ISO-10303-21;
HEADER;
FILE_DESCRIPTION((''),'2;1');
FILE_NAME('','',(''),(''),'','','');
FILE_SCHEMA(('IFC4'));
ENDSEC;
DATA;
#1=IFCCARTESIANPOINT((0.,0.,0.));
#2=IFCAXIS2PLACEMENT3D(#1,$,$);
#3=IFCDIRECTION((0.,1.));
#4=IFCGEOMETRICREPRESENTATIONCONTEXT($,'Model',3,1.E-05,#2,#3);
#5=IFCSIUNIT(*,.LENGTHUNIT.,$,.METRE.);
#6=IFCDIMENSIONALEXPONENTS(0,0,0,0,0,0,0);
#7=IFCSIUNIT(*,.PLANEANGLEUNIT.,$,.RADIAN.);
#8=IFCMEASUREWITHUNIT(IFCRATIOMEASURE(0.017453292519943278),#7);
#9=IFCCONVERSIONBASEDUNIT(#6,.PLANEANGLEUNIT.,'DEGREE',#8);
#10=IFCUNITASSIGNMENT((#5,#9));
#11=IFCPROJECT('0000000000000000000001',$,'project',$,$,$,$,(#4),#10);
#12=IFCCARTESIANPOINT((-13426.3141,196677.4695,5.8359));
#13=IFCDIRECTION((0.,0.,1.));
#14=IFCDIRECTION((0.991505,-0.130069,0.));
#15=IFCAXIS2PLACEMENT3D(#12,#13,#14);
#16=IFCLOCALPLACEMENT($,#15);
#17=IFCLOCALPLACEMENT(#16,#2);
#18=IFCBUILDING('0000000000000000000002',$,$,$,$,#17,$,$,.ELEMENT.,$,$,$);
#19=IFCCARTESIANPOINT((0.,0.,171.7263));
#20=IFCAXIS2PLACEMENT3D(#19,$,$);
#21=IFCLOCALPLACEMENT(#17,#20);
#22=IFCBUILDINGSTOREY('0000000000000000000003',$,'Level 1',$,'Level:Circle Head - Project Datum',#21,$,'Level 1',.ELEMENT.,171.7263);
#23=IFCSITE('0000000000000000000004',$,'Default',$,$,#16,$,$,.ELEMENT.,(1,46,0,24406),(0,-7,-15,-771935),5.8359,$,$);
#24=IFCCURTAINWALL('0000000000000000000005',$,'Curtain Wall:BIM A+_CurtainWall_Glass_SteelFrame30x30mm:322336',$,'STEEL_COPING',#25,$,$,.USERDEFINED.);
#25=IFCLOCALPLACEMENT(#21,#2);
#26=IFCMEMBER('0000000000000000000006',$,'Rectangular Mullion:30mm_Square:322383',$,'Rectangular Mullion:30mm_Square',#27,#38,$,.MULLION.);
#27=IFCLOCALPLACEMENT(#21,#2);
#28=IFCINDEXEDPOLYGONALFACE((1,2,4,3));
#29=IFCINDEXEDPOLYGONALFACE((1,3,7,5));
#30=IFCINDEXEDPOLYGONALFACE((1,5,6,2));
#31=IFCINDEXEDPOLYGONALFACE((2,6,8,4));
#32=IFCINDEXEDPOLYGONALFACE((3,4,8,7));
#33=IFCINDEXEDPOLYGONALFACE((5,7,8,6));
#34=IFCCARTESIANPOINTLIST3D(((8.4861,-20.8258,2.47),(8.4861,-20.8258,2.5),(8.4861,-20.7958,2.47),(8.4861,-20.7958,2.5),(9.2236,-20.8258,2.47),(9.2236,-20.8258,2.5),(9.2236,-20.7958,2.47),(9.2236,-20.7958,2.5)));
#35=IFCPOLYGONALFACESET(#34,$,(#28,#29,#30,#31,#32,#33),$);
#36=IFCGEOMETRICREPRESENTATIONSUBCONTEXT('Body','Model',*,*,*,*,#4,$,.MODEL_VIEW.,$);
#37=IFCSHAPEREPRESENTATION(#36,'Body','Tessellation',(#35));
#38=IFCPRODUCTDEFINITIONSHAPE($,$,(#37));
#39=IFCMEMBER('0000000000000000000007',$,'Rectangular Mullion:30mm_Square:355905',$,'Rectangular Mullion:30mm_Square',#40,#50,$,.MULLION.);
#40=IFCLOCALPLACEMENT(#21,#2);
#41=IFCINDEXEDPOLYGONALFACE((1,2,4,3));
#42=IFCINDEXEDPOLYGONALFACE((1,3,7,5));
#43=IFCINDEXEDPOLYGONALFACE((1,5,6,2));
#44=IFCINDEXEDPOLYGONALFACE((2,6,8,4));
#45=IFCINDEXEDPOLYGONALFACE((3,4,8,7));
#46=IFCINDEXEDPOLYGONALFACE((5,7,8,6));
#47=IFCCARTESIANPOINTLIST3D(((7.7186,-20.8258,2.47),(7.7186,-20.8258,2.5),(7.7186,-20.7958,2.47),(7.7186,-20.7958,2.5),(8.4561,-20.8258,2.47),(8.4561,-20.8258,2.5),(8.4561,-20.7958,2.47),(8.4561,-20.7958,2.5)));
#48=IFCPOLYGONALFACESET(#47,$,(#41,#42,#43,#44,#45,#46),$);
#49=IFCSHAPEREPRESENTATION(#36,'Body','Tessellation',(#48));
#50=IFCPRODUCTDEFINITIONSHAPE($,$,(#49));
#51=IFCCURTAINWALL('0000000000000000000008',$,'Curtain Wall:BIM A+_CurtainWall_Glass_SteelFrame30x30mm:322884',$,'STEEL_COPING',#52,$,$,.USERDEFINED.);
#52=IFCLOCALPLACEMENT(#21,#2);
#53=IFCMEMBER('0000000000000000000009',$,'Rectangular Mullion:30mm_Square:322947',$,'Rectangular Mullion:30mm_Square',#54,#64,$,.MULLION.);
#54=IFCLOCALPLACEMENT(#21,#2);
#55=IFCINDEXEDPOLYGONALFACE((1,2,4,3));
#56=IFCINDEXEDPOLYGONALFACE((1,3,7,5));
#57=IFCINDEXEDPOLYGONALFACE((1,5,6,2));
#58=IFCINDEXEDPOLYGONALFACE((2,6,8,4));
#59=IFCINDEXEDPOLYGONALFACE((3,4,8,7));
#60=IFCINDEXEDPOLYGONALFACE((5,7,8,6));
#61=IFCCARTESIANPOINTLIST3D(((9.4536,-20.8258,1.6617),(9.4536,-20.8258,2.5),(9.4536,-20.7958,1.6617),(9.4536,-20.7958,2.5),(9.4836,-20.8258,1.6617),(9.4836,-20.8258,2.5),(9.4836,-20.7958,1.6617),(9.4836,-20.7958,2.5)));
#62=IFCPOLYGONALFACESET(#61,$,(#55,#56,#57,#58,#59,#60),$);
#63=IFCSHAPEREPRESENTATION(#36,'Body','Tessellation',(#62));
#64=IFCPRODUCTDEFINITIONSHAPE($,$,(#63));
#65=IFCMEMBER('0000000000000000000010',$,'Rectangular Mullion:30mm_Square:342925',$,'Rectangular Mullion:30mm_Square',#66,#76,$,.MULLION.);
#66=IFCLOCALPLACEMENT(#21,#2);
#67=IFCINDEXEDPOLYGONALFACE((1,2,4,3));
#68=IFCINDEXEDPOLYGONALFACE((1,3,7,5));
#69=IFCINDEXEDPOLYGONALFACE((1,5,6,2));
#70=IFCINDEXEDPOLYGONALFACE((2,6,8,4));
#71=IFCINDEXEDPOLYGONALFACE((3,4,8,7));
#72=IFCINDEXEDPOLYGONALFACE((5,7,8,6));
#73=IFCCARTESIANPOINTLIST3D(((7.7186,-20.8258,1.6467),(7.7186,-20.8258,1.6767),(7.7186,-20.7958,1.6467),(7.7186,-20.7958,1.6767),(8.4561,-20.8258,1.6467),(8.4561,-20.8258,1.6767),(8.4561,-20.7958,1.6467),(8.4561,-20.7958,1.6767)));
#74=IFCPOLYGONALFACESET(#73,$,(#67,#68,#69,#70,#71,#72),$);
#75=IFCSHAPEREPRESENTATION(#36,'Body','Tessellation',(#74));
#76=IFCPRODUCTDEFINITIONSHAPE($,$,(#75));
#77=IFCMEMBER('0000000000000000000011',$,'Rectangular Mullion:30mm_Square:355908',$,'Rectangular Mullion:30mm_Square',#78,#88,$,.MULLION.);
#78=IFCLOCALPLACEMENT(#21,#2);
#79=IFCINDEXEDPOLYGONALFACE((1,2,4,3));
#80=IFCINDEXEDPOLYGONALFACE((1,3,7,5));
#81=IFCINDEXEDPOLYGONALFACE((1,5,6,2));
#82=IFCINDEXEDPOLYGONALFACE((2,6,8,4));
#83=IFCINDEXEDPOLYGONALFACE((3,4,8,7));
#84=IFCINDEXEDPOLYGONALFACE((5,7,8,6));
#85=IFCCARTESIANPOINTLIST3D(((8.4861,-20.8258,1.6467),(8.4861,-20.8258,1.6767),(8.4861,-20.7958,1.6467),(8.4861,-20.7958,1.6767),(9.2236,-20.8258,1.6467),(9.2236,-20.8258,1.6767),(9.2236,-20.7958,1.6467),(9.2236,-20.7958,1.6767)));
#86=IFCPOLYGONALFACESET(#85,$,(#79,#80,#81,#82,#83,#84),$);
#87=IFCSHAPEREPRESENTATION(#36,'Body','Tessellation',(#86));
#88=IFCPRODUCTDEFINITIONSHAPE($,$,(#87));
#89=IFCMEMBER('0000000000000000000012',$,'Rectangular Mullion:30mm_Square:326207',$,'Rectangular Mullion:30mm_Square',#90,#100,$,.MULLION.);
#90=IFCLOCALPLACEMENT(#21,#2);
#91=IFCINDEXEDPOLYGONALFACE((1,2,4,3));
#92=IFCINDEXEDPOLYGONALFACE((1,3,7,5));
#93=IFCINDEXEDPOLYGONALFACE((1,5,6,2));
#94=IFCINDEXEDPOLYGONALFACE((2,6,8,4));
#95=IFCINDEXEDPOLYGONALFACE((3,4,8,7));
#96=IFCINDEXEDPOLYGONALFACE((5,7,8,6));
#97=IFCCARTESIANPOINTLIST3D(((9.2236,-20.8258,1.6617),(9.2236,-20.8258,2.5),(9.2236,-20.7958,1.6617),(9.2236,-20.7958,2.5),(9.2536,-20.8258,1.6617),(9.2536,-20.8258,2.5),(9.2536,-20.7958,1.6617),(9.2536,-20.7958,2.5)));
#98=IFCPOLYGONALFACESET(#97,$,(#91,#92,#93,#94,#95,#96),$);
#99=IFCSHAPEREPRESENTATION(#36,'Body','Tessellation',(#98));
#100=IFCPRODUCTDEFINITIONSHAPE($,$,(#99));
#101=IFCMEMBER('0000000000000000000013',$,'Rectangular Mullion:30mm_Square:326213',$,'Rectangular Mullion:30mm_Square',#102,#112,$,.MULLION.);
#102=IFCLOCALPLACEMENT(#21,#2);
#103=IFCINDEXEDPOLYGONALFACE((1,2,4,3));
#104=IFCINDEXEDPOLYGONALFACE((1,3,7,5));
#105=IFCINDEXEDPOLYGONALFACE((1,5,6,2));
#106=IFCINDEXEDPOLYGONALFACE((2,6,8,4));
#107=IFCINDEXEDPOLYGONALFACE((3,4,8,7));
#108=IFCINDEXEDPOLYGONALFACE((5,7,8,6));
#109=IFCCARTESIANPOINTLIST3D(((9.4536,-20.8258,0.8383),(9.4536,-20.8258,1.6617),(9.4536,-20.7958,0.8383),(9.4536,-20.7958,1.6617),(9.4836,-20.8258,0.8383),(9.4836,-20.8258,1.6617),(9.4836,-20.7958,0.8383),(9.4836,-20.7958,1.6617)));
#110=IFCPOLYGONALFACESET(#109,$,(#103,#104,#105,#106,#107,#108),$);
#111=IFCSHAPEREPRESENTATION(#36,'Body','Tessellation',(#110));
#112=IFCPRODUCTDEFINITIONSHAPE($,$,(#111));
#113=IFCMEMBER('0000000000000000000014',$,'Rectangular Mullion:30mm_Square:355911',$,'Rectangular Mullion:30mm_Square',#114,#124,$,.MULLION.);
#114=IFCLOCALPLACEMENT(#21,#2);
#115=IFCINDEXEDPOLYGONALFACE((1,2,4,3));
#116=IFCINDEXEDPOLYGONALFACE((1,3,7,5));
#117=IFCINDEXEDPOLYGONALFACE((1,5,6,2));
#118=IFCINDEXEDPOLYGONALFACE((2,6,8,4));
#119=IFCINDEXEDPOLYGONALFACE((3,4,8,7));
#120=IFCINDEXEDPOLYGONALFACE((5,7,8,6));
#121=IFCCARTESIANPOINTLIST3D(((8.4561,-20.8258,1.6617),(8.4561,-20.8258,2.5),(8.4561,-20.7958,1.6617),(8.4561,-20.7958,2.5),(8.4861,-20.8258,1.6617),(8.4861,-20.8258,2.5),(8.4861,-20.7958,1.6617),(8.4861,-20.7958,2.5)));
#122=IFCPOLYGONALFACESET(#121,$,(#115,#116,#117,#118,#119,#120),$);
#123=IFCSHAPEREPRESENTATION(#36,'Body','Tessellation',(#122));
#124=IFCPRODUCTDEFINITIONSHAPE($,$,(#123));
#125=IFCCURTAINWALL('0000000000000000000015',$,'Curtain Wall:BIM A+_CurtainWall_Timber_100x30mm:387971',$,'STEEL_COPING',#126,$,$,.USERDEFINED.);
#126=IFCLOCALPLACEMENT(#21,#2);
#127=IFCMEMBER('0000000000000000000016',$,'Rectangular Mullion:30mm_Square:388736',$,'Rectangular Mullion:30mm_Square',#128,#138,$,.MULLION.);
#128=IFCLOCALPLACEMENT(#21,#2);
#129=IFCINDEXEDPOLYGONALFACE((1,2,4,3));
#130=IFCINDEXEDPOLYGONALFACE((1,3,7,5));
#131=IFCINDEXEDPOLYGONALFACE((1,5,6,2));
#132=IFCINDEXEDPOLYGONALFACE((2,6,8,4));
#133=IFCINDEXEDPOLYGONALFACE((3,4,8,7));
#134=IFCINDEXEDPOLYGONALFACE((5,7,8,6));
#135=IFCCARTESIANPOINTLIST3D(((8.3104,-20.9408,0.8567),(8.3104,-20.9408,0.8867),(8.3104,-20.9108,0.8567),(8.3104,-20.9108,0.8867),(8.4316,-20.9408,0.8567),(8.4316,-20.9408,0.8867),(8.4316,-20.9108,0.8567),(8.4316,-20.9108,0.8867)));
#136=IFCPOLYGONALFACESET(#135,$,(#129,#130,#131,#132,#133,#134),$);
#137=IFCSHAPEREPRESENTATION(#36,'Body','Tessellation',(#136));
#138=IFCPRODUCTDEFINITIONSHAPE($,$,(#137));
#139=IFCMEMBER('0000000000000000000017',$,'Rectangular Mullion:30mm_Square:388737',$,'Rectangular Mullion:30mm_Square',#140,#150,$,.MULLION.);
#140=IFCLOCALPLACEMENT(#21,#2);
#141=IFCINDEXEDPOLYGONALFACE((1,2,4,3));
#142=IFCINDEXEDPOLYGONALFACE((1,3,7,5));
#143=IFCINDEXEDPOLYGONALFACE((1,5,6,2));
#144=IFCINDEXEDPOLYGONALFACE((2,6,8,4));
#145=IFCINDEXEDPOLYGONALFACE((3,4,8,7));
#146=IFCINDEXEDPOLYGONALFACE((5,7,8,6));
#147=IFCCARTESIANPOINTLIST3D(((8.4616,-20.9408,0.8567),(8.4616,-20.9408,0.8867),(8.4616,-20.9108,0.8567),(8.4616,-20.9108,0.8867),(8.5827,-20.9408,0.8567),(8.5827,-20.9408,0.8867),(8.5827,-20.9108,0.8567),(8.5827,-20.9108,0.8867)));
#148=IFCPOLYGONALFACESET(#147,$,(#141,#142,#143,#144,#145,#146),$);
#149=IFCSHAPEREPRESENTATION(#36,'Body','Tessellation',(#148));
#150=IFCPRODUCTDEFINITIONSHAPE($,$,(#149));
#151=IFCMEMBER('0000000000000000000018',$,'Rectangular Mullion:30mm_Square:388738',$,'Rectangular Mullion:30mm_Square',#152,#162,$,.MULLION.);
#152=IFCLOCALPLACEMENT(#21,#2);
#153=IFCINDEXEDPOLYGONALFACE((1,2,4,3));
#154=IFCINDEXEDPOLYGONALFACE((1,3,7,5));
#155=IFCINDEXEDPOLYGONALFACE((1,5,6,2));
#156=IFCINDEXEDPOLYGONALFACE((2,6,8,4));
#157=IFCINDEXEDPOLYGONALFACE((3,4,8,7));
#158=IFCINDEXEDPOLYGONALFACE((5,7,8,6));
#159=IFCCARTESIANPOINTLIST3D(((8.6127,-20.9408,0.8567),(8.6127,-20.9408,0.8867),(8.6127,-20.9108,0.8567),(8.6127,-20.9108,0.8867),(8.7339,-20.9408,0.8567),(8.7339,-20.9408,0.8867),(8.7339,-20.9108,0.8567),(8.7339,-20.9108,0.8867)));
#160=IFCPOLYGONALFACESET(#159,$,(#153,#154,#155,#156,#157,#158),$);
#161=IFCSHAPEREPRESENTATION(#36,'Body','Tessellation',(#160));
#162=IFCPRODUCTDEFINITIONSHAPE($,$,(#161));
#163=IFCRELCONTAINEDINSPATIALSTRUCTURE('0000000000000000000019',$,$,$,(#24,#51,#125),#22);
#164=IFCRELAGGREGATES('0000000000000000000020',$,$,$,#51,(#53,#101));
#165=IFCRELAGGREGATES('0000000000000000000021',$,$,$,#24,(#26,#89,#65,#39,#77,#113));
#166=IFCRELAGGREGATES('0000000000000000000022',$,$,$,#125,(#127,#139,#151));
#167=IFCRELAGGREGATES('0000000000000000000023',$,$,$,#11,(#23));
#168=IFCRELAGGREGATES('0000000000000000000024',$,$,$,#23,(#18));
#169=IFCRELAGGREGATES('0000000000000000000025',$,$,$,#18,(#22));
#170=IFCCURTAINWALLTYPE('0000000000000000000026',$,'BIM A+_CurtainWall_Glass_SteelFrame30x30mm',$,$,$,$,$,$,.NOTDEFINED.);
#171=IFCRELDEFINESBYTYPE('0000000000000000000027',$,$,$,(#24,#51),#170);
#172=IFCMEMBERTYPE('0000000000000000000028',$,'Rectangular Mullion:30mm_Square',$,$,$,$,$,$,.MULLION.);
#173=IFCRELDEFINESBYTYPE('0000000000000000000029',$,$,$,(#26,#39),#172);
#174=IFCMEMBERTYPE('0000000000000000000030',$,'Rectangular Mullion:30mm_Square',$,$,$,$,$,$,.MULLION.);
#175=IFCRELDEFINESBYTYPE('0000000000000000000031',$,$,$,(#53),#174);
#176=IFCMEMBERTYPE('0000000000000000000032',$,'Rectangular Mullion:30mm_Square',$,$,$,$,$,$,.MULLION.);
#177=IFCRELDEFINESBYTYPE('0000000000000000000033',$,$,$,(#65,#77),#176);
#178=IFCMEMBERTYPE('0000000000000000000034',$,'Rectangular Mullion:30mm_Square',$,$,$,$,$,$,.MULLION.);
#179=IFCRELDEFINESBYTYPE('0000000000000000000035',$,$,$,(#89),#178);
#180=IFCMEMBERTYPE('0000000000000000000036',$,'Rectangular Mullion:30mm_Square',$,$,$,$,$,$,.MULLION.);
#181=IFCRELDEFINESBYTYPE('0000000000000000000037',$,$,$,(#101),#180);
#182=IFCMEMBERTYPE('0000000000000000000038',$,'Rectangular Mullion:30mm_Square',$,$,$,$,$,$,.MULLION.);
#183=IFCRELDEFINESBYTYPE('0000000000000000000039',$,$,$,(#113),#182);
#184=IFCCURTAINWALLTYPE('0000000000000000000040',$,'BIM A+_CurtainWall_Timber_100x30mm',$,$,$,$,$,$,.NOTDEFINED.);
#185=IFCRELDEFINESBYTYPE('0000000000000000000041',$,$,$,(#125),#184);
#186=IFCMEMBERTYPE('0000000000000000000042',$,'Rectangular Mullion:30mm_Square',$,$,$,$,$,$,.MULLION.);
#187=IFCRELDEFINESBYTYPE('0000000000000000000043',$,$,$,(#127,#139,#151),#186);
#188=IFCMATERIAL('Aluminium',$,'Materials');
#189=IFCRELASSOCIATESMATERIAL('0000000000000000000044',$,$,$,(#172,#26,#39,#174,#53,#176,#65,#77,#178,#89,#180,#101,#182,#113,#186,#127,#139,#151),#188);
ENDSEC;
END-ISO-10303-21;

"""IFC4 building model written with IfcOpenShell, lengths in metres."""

from ifc_helpers import new_model, entity, si_unit, converted_unit, direction, frame, origin, place, context, subcontext, project, spatial, indexed_curve, outline, extrude, source, transform, mapped, material, type_object, type_shapes, element, aggregate, save


model = new_model("IFC4")

# Units and contexts
model_context = context("Model", 3, precision=1e-05, world=origin(), true_north=direction((0.0, 1.0)))
body_context = subcontext(model_context, "Body", "Model", "MODEL_VIEW")
ifc_project = project(units=[si_unit("LENGTHUNIT", "METRE"), converted_unit("PLANEANGLEUNIT", "DEGREE", entity("IfcRatioMeasure", 0.017453292519943278), si_unit("PLANEANGLEUNIT", "RADIAN"), dimensions=[0, 0, 0, 0, 0, 0, 0])], contexts=[model_context])

# Site, building, storey
site_placement = place(None, frame((-13426.3141, 196677.4695, 5.8359), z_axis=(0.0, 0.0, 1.0), x_axis=(0.991505, -0.130069, 0.0)))
site = spatial("IfcSite", under=ifc_project, at=site_placement, Name="Default", CompositionType="ELEMENT", RefLatitude=(1, 46, 0, 24406), RefLongitude=(0, -7, -15, -771935), RefElevation=5.8359)
building_placement = place(site_placement, origin())
building = spatial("IfcBuilding", under=site, at=building_placement, CompositionType="ELEMENT")
storey_placement = place(building_placement, frame((0.0, 0.0, 171.7263)))
storey = spatial("IfcBuildingStorey", under=building, at=storey_placement, Name="Level 1", ObjectType="Level:Circle Head - Project Datum", LongName="Level 1", CompositionType="ELEMENT", Elevation=171.7263)

# Curtain wall, members
curtain_wall_type_1 = type_object("IfcCurtainWallType", Name="BIM A+_CurtainWall_Glass_SteelFrame30x30mm", PredefinedType="NOTDEFINED")
curtain_wall_1_placement = place(storey_placement, frame((0.0, 0.0, -171.7263)))
curtain_wall_1 = element("IfcCurtainWall", 1, at=curtain_wall_1_placement, inside=storey, type_object=curtain_wall_type_1, Name="Curtain Wall:BIM A+_CurtainWall_Glass_SteelFrame30x30mm:322336", ObjectType="STEEL_COPING", PredefinedType="USERDEFINED")
ifc_material_1 = material(Name="Aluminium", Category="Materials")
member_type_1 = type_object("IfcMemberType", Name="Rectangular Mullion:30mm_Square", PredefinedType="MULLION", material=ifc_material_1)
shared_shape_1 = source(origin(), body_context, "Body", "SweptSolid", [
    extrude(outline(indexed_curve([(-0.015, -0.015), (0.015, -0.015), (0.015, 0.015), (-0.015, 0.015), (-0.015, -0.015)], self_intersect=False)), frame((-0.015, 0.0, -0.7375), z_axis=(0.0, 0.0, 1.0), x_axis=(0.0, -1.0, 0.0)), (0.0, 0.0, 1.0), 0.7375),
])
type_shapes(member_type_1, [shared_shape_1])
member_1_placement = place(curtain_wall_1_placement, frame((9.2236, -20.8108, 174.2263), z_axis=(1.0, 0.0, 0.0), x_axis=(0.0, 0.0, 1.0)))
member_1 = element("IfcMember", 2, at=member_1_placement, type_object=member_type_1, material=ifc_material_1, Name="Rectangular Mullion:30mm_Square:322383", ObjectType="Rectangular Mullion:30mm_Square", PredefinedType="MULLION", context=body_context, shape_type="MappedRepresentation", body=[
    mapped(shared_shape_1, transform((0.0, 0.0, 0.0), scale=1.0)),
])
member_2_placement = place(curtain_wall_1_placement, frame((8.4561, -20.8108, 174.2263), z_axis=(1.0, 0.0, 0.0), x_axis=(0.0, 0.0, 1.0)))
member_2 = element("IfcMember", 3, at=member_2_placement, type_object=member_type_1, material=ifc_material_1, Name="Rectangular Mullion:30mm_Square:355905", ObjectType="Rectangular Mullion:30mm_Square", PredefinedType="MULLION", context=body_context, shape_type="MappedRepresentation", body=[
    mapped(shared_shape_1, transform((0.0, 0.0, 0.0), scale=1.0)),
])

# Curtain wall, member
curtain_wall_2_placement = place(storey_placement, frame((0.0, 0.0, -171.7263)))
curtain_wall_2 = element("IfcCurtainWall", 4, at=curtain_wall_2_placement, inside=storey, type_object=curtain_wall_type_1, Name="Curtain Wall:BIM A+_CurtainWall_Glass_SteelFrame30x30mm:322884", ObjectType="STEEL_COPING", PredefinedType="USERDEFINED")
member_type_2 = type_object("IfcMemberType", Name="Rectangular Mullion:30mm_Square", PredefinedType="MULLION", material=ifc_material_1)
shared_shape_2 = source(origin(), body_context, "Body", "SweptSolid", [
    extrude(outline(indexed_curve([(-0.015, -0.015), (0.015, -0.015), (0.015, 0.015), (-0.015, 0.015), (-0.015, -0.015)], self_intersect=False)), frame((-0.015, 0.0, -0.8383), z_axis=(0.0, 0.0, 1.0), x_axis=(0.0, -1.0, 0.0)), (0.0, 0.0, 1.0), 0.8383),
])
type_shapes(member_type_2, [shared_shape_2])
member_3_placement = place(curtain_wall_2_placement, frame((9.4536, -20.8108, 174.2263), z_axis=(0.0, 0.0, 1.0), x_axis=(-1.0, 0.0, 0.0)))
member_3 = element("IfcMember", 5, at=member_3_placement, type_object=member_type_2, material=ifc_material_1, Name="Rectangular Mullion:30mm_Square:322947", ObjectType="Rectangular Mullion:30mm_Square", PredefinedType="MULLION", context=body_context, shape_type="MappedRepresentation", body=[
    mapped(shared_shape_2, transform((0.0, 0.0, 0.0), scale=1.0)),
])

# Members
member_type_3 = type_object("IfcMemberType", Name="Rectangular Mullion:30mm_Square", PredefinedType="MULLION", material=ifc_material_1)
shared_shape_3 = source(origin(), body_context, "Body", "SweptSolid", [
    extrude(outline(indexed_curve([(-0.015, -0.015), (0.015, -0.015), (0.015, 0.015), (-0.015, 0.015), (-0.015, -0.015)], self_intersect=False)), frame((0.0, 0.0, -0.7375), z_axis=(0.0, 0.0, 1.0), x_axis=(0.0, -1.0, 0.0)), (0.0, 0.0, 1.0), 0.7375),
])
type_shapes(member_type_3, [shared_shape_3])
member_4_placement = place(curtain_wall_1_placement, frame((8.4561, -20.8108, 173.3879), z_axis=(1.0, 0.0, 0.0), x_axis=(0.0, 0.0, 1.0)))
member_4 = element("IfcMember", 6, at=member_4_placement, type_object=member_type_3, material=ifc_material_1, Name="Rectangular Mullion:30mm_Square:342925", ObjectType="Rectangular Mullion:30mm_Square", PredefinedType="MULLION", context=body_context, shape_type="MappedRepresentation", body=[
    mapped(shared_shape_3, transform((0.0, 0.0, 0.0), scale=1.0)),
])
member_5_placement = place(curtain_wall_1_placement, frame((9.2236, -20.8108, 173.3879), z_axis=(1.0, 0.0, 0.0), x_axis=(0.0, 0.0, 1.0)))
member_5 = element("IfcMember", 7, at=member_5_placement, type_object=member_type_3, material=ifc_material_1, Name="Rectangular Mullion:30mm_Square:355908", ObjectType="Rectangular Mullion:30mm_Square", PredefinedType="MULLION", context=body_context, shape_type="MappedRepresentation", body=[
    mapped(shared_shape_3, transform((0.0, 0.0, 0.0), scale=1.0)),
])
member_type_4 = type_object("IfcMemberType", Name="Rectangular Mullion:30mm_Square", PredefinedType="MULLION", material=ifc_material_1)
shared_shape_4 = source(origin(), body_context, "Body", "SweptSolid", [
    extrude(outline(indexed_curve([(-0.015, -0.015), (0.015, -0.015), (0.015, 0.015), (-0.015, 0.015), (-0.015, -0.015)], self_intersect=False)), frame((-0.015, 0.0, -0.8383), z_axis=(0.0, 0.0, 1.0), x_axis=(0.0, -1.0, 0.0)), (0.0, 0.0, 1.0), 0.8383),
])
type_shapes(member_type_4, [shared_shape_4])
member_6_placement = place(curtain_wall_1_placement, frame((9.2536, -20.8108, 173.3879), z_axis=(0.0, 0.0, -1.0), x_axis=(1.0, 0.0, 0.0)))
member_6 = element("IfcMember", 8, at=member_6_placement, type_object=member_type_4, material=ifc_material_1, Name="Rectangular Mullion:30mm_Square:326207", ObjectType="Rectangular Mullion:30mm_Square", PredefinedType="MULLION", context=body_context, shape_type="MappedRepresentation", body=[
    mapped(shared_shape_4, transform((0.0, 0.0, 0.0), scale=1.0)),
])
member_type_5 = type_object("IfcMemberType", Name="Rectangular Mullion:30mm_Square", PredefinedType="MULLION", material=ifc_material_1)
shared_shape_5 = source(origin(), body_context, "Body", "SweptSolid", [
    extrude(outline(indexed_curve([(-0.015, -0.015), (0.015, -0.015), (0.015, 0.015), (-0.015, 0.015), (-0.015, -0.015)], self_intersect=False)), frame((-0.015, 0.0, -0.8233), z_axis=(0.0, 0.0, 1.0), x_axis=(0.0, -1.0, 0.0)), (0.0, 0.0, 1.0), 0.8233),
])
type_shapes(member_type_5, [shared_shape_5])
member_7_placement = place(curtain_wall_2_placement, frame((9.4536, -20.8108, 173.3879), z_axis=(0.0, 0.0, 1.0), x_axis=(-1.0, 0.0, 0.0)))
member_7 = element("IfcMember", 9, at=member_7_placement, type_object=member_type_5, material=ifc_material_1, Name="Rectangular Mullion:30mm_Square:326213", ObjectType="Rectangular Mullion:30mm_Square", PredefinedType="MULLION", context=body_context, shape_type="MappedRepresentation", body=[
    mapped(shared_shape_5, transform((0.0, 0.0, 0.0), scale=1.0)),
])
aggregate(curtain_wall_2, [member_3, member_7])
member_type_6 = type_object("IfcMemberType", Name="Rectangular Mullion:30mm_Square", PredefinedType="MULLION", material=ifc_material_1)
shared_shape_6 = source(origin(), body_context, "Body", "SweptSolid", [
    extrude(outline(indexed_curve([(-0.015, -0.015), (0.015, -0.015), (0.015, 0.015), (-0.015, 0.015), (-0.015, -0.015)], self_intersect=False)), frame((0.0, 0.0, -0.8383), z_axis=(0.0, 0.0, 1.0), x_axis=(0.0, -1.0, 0.0)), (0.0, 0.0, 1.0), 0.8383),
])
type_shapes(member_type_6, [shared_shape_6])
member_8_placement = place(curtain_wall_1_placement, frame((8.4711, -20.8108, 173.3879), z_axis=(0.0, 0.0, -1.0), x_axis=(1.0, 0.0, 0.0)))
member_8 = element("IfcMember", 10, at=member_8_placement, type_object=member_type_6, material=ifc_material_1, Name="Rectangular Mullion:30mm_Square:355911", ObjectType="Rectangular Mullion:30mm_Square", PredefinedType="MULLION", context=body_context, shape_type="MappedRepresentation", body=[
    mapped(shared_shape_6, transform((0.0, 0.0, 0.0), scale=1.0)),
])

# Curtain wall, members
curtain_wall_type_2 = type_object("IfcCurtainWallType", Name="BIM A+_CurtainWall_Timber_100x30mm", PredefinedType="NOTDEFINED")
curtain_wall_3_placement = place(storey_placement, frame((0.0, 0.0, -171.7263)))
curtain_wall_3 = element("IfcCurtainWall", 11, at=curtain_wall_3_placement, inside=storey, type_object=curtain_wall_type_2, Name="Curtain Wall:BIM A+_CurtainWall_Timber_100x30mm:387971", ObjectType="STEEL_COPING", PredefinedType="USERDEFINED")
member_type_7 = type_object("IfcMemberType", Name="Rectangular Mullion:30mm_Square", PredefinedType="MULLION", material=ifc_material_1)
shared_shape_7 = source(origin(), body_context, "Body", "SweptSolid", [
    extrude(outline(indexed_curve([(-0.015, -0.015), (0.015, -0.015), (0.015, 0.015), (-0.015, 0.015), (-0.015, -0.015)], self_intersect=False)), frame((0.0, 0.0, -0.1212), z_axis=(0.0, 0.0, 1.0), x_axis=(0.0, -1.0, 0.0)), (0.0, 0.0, 1.0), 0.1212),
])
type_shapes(member_type_7, [shared_shape_7])
member_9_placement = place(curtain_wall_3_placement, frame((8.4316, -20.9258, 172.598), z_axis=(1.0, 0.0, 0.0), x_axis=(0.0, 0.0, 1.0)))
member_9 = element("IfcMember", 12, at=member_9_placement, type_object=member_type_7, material=ifc_material_1, Name="Rectangular Mullion:30mm_Square:388736", ObjectType="Rectangular Mullion:30mm_Square", PredefinedType="MULLION", context=body_context, shape_type="MappedRepresentation", body=[
    mapped(shared_shape_7, transform((0.0, 0.0, 0.0), scale=1.0)),
])
member_10_placement = place(curtain_wall_3_placement, frame((8.5827, -20.9258, 172.598), z_axis=(1.0, 0.0, 0.0), x_axis=(0.0, 0.0, 1.0)))
member_10 = element("IfcMember", 13, at=member_10_placement, type_object=member_type_7, material=ifc_material_1, Name="Rectangular Mullion:30mm_Square:388737", ObjectType="Rectangular Mullion:30mm_Square", PredefinedType="MULLION", context=body_context, shape_type="MappedRepresentation", body=[
    mapped(shared_shape_7, transform((0.0, 0.0, 0.0), scale=1.0)),
])
member_11_placement = place(curtain_wall_3_placement, frame((8.7339, -20.9258, 172.598), z_axis=(1.0, 0.0, 0.0), x_axis=(0.0, 0.0, 1.0)))
member_11 = element("IfcMember", 14, at=member_11_placement, type_object=member_type_7, material=ifc_material_1, Name="Rectangular Mullion:30mm_Square:388738", ObjectType="Rectangular Mullion:30mm_Square", PredefinedType="MULLION", context=body_context, shape_type="MappedRepresentation", body=[
    mapped(shared_shape_7, transform((0.0, 0.0, 0.0), scale=1.0)),
])

aggregate(curtain_wall_1, [member_1, member_6, member_4, member_2, member_5, member_8])
aggregate(curtain_wall_3, [member_9, member_10, member_11])

save(model, "model.ifc")
